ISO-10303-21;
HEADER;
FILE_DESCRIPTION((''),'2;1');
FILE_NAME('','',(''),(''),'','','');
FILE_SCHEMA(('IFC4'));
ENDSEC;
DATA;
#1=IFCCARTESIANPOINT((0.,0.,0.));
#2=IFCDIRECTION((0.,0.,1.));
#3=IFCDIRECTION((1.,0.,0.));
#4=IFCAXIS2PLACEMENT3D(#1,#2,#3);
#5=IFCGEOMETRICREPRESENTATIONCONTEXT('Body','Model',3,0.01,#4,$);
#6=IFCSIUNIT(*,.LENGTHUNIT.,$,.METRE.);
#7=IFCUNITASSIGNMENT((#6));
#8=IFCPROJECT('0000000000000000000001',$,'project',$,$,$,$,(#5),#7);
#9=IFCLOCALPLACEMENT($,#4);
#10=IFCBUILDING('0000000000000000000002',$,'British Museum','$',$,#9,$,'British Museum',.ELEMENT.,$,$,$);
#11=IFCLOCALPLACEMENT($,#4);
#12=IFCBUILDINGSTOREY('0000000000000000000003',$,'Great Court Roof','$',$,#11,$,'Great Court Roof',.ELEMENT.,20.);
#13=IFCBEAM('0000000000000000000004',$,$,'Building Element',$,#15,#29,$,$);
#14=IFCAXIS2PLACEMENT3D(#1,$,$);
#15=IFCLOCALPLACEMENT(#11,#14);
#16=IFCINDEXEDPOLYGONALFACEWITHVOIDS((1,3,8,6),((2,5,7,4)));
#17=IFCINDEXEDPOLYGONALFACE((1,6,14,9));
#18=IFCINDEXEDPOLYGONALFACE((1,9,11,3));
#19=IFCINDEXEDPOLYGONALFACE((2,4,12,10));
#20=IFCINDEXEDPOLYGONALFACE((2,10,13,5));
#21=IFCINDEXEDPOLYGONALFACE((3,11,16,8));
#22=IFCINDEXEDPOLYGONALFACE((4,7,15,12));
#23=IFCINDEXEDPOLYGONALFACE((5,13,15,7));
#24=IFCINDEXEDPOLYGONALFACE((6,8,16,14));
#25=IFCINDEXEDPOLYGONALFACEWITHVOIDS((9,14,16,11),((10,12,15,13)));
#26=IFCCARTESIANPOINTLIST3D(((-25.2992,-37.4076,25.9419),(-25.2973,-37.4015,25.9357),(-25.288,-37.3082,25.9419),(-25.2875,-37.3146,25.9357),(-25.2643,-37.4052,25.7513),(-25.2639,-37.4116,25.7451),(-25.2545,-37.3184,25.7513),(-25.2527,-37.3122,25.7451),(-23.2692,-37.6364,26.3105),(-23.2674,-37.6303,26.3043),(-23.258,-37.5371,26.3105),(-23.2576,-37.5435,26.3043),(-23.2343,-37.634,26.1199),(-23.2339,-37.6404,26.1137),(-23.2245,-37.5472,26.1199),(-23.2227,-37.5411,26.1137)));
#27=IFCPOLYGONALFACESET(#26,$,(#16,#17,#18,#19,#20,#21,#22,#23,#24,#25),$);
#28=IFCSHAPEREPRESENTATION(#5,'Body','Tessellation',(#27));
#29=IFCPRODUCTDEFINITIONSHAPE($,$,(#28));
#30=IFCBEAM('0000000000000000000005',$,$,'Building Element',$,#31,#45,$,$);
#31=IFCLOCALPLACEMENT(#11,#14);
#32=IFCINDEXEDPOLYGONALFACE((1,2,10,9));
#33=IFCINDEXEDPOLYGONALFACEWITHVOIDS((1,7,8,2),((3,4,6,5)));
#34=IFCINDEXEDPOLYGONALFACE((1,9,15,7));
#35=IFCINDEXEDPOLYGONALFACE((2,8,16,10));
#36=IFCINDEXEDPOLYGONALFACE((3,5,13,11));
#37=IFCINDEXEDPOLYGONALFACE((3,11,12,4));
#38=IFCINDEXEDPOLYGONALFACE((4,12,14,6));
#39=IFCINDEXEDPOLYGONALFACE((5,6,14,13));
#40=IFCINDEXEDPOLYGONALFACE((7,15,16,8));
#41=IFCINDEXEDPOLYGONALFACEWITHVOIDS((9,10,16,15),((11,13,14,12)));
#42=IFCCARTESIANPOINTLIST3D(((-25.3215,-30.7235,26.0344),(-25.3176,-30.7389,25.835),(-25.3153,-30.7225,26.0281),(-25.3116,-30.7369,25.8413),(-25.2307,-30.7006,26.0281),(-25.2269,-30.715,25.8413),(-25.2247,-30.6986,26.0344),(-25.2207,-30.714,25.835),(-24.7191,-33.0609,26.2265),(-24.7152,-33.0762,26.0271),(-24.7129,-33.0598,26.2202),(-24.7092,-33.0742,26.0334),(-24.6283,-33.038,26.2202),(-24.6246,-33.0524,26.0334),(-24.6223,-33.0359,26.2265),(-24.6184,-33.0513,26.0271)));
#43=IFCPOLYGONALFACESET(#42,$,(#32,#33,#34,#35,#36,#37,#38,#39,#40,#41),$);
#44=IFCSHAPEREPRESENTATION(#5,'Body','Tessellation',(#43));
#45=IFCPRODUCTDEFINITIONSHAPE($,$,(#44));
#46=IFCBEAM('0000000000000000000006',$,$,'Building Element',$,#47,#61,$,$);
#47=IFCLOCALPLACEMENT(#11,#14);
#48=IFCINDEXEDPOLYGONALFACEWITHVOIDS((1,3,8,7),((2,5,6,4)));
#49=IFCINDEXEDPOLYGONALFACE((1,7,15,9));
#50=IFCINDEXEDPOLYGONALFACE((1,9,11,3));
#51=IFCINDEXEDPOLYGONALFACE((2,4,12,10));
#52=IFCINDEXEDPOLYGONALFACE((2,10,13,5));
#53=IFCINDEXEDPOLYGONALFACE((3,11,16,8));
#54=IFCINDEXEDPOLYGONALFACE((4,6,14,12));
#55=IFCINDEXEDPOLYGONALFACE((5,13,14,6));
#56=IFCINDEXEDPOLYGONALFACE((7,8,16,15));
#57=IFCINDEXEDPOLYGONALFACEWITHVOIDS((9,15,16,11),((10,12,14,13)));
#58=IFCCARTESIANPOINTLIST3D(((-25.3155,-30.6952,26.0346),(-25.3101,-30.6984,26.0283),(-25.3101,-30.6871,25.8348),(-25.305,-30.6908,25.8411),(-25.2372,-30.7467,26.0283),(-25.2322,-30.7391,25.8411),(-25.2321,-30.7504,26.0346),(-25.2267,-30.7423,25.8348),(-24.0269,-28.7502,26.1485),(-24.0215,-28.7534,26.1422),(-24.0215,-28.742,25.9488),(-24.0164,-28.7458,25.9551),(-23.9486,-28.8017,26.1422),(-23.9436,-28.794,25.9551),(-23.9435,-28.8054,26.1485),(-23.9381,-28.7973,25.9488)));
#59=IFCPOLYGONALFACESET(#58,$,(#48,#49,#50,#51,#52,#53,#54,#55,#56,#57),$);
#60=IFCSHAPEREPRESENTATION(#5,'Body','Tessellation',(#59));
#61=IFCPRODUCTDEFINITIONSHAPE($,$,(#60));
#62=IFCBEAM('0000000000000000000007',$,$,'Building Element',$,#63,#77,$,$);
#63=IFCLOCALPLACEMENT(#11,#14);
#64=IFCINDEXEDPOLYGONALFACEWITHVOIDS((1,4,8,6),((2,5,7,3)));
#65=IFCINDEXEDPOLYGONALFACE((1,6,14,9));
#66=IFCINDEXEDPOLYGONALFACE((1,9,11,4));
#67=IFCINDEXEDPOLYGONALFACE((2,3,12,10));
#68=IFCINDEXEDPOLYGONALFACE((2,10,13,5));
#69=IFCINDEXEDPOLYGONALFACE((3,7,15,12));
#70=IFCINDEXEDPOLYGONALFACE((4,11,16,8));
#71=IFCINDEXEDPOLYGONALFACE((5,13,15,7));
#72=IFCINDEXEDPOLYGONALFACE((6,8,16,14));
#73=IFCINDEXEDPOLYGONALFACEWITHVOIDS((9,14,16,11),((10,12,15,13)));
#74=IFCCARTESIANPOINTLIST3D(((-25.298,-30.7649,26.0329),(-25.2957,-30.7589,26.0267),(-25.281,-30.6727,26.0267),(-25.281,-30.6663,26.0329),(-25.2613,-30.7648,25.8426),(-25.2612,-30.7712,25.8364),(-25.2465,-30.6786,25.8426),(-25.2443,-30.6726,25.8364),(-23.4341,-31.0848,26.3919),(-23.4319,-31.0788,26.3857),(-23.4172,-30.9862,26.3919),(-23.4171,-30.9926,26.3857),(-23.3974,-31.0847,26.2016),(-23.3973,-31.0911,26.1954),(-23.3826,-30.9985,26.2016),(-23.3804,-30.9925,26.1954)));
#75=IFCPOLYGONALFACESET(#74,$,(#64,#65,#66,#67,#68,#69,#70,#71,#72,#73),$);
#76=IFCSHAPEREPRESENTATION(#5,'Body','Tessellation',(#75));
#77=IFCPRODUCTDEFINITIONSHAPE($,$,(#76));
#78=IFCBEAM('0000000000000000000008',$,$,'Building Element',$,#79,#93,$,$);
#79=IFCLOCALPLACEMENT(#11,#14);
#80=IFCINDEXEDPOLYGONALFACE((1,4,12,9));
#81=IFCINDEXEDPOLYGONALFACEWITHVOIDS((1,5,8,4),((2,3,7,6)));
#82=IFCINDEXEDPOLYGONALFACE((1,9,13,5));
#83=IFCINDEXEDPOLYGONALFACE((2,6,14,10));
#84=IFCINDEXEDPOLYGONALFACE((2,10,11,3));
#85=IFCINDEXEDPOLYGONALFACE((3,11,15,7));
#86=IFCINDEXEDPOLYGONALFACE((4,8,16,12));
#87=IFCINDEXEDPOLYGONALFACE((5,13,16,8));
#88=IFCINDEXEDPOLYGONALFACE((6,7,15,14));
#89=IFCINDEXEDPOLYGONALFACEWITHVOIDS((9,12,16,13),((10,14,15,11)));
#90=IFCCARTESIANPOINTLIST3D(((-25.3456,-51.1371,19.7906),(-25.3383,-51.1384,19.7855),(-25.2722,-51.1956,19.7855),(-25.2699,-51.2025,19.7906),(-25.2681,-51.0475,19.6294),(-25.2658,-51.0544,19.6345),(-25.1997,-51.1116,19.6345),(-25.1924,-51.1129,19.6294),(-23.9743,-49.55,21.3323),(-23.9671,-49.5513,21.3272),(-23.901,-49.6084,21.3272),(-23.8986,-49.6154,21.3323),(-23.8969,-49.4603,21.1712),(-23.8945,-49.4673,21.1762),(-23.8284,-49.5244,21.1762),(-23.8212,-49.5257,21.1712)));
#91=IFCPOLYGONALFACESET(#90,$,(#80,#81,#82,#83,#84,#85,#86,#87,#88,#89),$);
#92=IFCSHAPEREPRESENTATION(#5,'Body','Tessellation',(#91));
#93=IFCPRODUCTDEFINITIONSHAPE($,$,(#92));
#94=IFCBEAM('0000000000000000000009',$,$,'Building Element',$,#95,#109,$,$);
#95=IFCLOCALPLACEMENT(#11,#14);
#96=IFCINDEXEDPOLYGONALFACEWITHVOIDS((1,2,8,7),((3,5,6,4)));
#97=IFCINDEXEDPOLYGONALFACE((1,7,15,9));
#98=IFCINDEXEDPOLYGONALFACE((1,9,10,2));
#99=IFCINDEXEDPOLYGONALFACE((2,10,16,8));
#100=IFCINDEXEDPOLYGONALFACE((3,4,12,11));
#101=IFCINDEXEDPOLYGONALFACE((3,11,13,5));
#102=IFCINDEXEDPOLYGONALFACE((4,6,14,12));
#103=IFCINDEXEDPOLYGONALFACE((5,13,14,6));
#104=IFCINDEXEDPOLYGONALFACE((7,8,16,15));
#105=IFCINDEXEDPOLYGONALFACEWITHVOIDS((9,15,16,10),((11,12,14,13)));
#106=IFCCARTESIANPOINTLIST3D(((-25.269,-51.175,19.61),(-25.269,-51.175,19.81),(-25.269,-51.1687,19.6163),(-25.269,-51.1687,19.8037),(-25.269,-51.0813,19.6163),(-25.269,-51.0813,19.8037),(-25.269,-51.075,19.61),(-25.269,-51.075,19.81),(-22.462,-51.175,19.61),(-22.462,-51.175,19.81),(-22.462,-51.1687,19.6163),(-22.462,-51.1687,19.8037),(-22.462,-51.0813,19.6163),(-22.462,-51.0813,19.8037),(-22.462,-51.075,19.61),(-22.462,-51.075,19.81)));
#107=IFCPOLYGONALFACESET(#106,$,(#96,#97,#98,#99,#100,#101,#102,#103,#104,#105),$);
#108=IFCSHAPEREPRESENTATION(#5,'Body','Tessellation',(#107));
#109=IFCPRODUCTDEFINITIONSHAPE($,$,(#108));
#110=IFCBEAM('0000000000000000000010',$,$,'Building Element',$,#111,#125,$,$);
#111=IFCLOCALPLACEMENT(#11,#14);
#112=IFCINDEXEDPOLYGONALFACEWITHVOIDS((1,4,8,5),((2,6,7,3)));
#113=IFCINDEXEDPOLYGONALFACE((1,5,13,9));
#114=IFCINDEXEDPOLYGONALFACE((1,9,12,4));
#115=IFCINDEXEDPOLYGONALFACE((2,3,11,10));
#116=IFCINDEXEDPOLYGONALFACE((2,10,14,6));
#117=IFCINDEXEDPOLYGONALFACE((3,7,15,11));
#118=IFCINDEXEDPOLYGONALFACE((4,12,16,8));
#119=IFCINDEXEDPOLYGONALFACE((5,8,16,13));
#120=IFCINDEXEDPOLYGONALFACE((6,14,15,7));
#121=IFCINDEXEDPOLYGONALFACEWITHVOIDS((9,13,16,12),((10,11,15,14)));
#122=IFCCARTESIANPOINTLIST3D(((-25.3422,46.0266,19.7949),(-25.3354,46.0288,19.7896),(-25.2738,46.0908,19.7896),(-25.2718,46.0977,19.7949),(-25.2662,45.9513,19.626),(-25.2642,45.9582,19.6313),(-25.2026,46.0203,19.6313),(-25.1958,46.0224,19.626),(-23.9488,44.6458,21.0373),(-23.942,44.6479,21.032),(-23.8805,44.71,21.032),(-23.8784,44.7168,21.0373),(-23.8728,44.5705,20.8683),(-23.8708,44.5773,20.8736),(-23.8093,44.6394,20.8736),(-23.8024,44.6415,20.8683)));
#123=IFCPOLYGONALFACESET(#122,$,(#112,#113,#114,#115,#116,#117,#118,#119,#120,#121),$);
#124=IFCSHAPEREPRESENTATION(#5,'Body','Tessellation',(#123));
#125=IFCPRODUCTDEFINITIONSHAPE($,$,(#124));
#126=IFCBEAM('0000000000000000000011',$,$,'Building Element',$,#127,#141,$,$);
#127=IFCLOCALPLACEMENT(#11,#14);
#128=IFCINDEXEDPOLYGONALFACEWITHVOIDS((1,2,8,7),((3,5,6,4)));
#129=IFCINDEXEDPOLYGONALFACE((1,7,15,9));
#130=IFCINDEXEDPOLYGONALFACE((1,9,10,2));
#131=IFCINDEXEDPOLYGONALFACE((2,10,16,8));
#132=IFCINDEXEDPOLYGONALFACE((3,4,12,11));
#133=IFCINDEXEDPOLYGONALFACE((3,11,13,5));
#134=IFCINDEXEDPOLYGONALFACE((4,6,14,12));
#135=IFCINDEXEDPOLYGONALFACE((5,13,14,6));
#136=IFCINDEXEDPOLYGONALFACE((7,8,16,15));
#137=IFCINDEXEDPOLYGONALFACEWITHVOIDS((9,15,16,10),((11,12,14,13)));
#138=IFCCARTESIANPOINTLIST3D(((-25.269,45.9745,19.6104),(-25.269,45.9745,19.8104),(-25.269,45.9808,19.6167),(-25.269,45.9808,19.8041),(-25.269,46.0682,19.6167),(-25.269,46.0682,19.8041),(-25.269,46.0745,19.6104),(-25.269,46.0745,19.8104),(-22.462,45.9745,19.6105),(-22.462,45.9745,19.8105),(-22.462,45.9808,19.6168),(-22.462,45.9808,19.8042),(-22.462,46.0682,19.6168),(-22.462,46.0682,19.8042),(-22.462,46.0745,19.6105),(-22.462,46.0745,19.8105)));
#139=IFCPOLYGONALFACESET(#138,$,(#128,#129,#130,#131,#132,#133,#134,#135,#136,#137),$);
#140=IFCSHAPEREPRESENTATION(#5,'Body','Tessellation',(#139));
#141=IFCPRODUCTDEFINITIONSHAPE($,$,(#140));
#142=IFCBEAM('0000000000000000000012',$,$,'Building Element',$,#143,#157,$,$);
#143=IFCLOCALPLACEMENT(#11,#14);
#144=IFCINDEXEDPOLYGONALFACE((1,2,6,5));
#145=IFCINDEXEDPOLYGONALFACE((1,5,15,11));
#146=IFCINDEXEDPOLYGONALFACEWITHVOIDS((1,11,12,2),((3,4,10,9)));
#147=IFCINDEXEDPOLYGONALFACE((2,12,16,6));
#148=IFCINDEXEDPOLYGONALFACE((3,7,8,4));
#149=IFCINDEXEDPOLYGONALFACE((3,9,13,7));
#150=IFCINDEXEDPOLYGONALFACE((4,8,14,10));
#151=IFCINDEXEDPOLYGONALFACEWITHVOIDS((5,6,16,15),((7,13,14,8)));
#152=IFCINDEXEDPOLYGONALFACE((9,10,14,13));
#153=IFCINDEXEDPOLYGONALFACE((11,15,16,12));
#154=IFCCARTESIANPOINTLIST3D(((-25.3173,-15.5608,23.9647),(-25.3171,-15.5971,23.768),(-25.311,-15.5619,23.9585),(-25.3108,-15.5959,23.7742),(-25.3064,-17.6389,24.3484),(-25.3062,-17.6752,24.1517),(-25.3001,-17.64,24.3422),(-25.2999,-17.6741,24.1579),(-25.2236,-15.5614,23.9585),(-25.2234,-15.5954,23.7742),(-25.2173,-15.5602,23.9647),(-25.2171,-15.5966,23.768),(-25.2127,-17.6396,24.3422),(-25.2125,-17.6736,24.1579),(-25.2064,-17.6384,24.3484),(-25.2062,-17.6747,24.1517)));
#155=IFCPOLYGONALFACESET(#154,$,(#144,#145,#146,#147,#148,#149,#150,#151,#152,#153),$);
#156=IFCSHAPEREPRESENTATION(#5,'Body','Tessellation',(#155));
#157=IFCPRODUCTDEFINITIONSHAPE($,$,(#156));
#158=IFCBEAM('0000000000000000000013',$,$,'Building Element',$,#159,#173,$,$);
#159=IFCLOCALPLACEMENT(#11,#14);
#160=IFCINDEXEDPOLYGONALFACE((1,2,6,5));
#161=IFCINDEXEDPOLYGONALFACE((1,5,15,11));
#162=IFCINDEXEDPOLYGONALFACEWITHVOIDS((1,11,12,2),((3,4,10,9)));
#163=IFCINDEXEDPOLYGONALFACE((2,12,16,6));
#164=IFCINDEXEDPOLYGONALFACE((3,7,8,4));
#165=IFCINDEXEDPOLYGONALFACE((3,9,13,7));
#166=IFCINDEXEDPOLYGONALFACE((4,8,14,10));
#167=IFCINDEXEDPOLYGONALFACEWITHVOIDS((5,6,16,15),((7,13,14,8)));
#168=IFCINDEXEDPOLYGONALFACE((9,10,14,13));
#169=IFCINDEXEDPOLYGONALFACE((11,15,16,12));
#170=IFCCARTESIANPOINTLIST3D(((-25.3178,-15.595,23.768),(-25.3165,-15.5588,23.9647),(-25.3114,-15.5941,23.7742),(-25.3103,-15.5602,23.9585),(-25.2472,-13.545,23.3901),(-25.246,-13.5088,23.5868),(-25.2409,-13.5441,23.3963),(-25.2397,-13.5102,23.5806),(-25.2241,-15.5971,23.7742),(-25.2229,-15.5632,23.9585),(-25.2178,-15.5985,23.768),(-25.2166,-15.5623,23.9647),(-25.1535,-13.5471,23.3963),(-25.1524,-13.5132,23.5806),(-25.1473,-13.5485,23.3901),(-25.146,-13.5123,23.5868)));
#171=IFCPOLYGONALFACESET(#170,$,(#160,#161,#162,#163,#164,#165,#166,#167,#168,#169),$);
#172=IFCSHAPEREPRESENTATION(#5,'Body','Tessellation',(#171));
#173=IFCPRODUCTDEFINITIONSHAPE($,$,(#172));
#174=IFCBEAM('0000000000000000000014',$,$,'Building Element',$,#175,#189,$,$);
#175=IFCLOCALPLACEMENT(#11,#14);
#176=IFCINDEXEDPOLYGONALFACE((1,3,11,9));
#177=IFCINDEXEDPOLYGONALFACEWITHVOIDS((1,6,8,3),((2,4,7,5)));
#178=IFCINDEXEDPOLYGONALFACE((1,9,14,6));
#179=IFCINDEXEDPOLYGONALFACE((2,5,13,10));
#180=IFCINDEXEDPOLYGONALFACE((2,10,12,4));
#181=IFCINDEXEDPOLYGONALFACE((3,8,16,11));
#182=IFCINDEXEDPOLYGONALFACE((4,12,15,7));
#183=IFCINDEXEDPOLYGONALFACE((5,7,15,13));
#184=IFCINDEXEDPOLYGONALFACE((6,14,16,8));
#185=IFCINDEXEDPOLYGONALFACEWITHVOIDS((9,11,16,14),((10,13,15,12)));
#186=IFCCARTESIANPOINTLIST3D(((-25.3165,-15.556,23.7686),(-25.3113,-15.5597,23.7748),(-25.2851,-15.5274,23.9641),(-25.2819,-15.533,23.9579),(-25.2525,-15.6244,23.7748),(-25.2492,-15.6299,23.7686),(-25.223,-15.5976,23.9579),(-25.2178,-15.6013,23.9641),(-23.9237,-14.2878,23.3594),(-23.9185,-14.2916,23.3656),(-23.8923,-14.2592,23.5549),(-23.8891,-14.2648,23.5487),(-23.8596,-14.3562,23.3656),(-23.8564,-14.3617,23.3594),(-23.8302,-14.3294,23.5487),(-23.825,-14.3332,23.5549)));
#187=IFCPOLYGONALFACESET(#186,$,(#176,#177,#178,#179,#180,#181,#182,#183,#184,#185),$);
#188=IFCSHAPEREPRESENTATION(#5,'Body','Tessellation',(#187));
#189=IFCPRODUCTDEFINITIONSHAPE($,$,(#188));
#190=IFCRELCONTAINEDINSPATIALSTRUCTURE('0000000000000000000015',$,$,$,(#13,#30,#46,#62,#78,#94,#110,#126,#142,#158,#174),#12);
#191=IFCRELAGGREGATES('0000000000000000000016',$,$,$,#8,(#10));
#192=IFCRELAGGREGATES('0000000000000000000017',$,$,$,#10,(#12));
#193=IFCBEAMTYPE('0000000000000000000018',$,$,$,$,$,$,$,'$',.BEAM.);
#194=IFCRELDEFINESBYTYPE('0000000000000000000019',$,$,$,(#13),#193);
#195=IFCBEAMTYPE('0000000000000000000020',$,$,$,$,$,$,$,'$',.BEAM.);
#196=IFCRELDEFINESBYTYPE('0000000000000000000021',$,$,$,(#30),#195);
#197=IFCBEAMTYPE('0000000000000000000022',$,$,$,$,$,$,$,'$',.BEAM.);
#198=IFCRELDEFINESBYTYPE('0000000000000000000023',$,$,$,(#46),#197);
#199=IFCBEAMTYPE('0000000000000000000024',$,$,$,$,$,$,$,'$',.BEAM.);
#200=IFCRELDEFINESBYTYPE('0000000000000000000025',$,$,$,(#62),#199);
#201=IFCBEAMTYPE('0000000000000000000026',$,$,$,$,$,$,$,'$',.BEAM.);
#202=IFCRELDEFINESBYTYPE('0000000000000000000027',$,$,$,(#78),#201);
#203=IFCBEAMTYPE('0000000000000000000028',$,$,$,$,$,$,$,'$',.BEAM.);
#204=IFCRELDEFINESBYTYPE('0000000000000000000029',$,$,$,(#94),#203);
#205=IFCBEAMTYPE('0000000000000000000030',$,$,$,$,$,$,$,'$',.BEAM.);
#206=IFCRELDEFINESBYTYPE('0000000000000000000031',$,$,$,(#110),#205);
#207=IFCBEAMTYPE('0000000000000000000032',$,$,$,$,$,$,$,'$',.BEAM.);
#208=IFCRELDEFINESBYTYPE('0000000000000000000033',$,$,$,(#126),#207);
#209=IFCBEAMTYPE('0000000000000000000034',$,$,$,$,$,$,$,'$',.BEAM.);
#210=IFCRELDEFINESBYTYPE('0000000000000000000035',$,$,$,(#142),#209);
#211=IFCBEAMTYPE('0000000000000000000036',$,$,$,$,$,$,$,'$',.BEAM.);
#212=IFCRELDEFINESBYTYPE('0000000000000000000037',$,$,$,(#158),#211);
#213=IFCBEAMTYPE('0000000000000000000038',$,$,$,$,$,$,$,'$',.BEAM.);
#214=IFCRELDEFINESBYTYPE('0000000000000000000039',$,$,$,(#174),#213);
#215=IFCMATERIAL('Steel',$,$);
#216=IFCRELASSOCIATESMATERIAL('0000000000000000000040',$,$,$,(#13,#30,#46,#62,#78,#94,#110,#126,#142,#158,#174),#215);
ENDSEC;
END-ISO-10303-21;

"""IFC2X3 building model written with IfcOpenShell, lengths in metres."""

from ifc_helpers import new_model, si_unit, frame, origin_with_axes, origin_2d, place, context, project, spatial, hollow_rectangle, extrude, material, type_object, element, save


model = new_model("IFC2X3")

# Units and contexts
model_context = context("Model", 3, precision=0.01, world=origin_with_axes(), identifier="Body")
ifc_project = project(units=[si_unit("LENGTHUNIT", "METRE")], contexts=[model_context])

# Building, storey
building_placement = place(None, origin_with_axes())
building = spatial("IfcBuilding", under=ifc_project, at=building_placement, Name="British Museum", Description="$", LongName="British Museum", CompositionType="ELEMENT")
storey_placement = place(None, origin_with_axes())
storey = spatial("IfcBuildingStorey", under=building, at=storey_placement, Name="Great Court Roof", Description="$", LongName="Great Court Roof", CompositionType="ELEMENT", Elevation=20.0)

# Beams
ifc_material = material(Name="Steel")
beam_type_1 = type_object("IfcBeamType", ElementType="$", PredefinedType="BEAM")
beam_1_placement = place(None, origin_with_axes())
element("IfcBeam", 1, at=beam_1_placement, inside=storey, type_object=beam_type_1, material=ifc_material, Description="Building Element", context=model_context, shape_type="SweptSolid", body=[
    extrude(hollow_rectangle(XDim=0.1, YDim=0.2, WallThickness=0.0063, InnerFilletRadius=-0.0063, OuterFilletRadius=0.0, at=origin_2d()), frame((-25.2759, -37.3599, 25.8435), z_axis=(0.977915, -0.110241, 0.177567), x_axis=(0.112021, 0.993706, 0.0)), (0.0, 0.0, 1.0), 2.0758),
])
beam_type_2 = type_object("IfcBeamType", ElementType="$", PredefinedType="BEAM")
beam_2_placement = place(None, origin_with_axes())
element("IfcBeam", 2, at=beam_2_placement, inside=storey, type_object=beam_type_2, material=ifc_material, Description="Building Element", context=model_context, shape_type="SweptSolid", body=[
    extrude(hollow_rectangle(XDim=0.1, YDim=0.2, WallThickness=0.0063, InnerFilletRadius=-0.0063, OuterFilletRadius=0.0, at=origin_2d()), frame((-25.2711, -30.7188, 25.9347), z_axis=(0.248778, -0.965305, 0.079343), x_axis=(0.968358, 0.249565, 0.0)), (0.0, 0.0, 1.0), 2.4213),
])
beam_type_3 = type_object("IfcBeamType", ElementType="$", PredefinedType="BEAM")
beam_3_placement = place(None, origin_with_axes())
element("IfcBeam", 3, at=beam_3_placement, inside=storey, type_object=beam_type_3, material=ifc_material, Description="Building Element", context=model_context, shape_type="SweptSolid", body=[
    extrude(hollow_rectangle(XDim=0.1, YDim=0.2, WallThickness=0.0063, InnerFilletRadius=-0.0063, OuterFilletRadius=0.0, at=origin_2d()), frame((-25.2711, -30.7188, 25.9347), z_axis=(0.551641, 0.832654, 0.048783), x_axis=(-0.833646, 0.552299, 0.0)), (0.0, 0.0, 1.0), 2.336),
])
beam_type_4 = type_object("IfcBeamType", ElementType="$", PredefinedType="BEAM")
beam_4_placement = place(None, origin_with_axes())
element("IfcBeam", 4, at=beam_4_placement, inside=storey, type_object=beam_type_4, material=ifc_material, Description="Building Element", context=model_context, shape_type="SweptSolid", body=[
    extrude(hollow_rectangle(XDim=0.1, YDim=0.2, WallThickness=0.0063, InnerFilletRadius=-0.0063, OuterFilletRadius=0.0, at=origin_2d()), frame((-25.2711, -30.7188, 25.9347), z_axis=(0.968303, -0.166189, 0.186467), x_axis=(0.169156, 0.985589, 0.0)), (0.0, 0.0, 1.0), 1.9249),
])
beam_type_5 = type_object("IfcBeamType", ElementType="$", PredefinedType="BEAM")
beam_5_placement = place(None, origin_with_axes())
element("IfcBeam", 5, at=beam_5_placement, inside=storey, type_object=beam_type_5, material=ifc_material, Description="Building Element", context=model_context, shape_type="SweptSolid", body=[
    extrude(hollow_rectangle(XDim=0.1, YDim=0.2, WallThickness=0.0063, InnerFilletRadius=-0.0063, OuterFilletRadius=0.0, at=origin_2d()), frame((-25.269, -51.125, 19.71), z_axis=(0.526768, 0.609708, 0.59226), x_axis=(-0.756698, 0.653764, 0.0)), (0.0, 0.0, 1.0), 2.6031),
])
beam_type_6 = type_object("IfcBeamType", ElementType="$", PredefinedType="BEAM")
beam_6_placement = place(None, origin_with_axes())
element("IfcBeam", 6, at=beam_6_placement, inside=storey, type_object=beam_type_6, material=ifc_material, Description="Building Element", context=model_context, shape_type="SweptSolid", body=[
    extrude(hollow_rectangle(XDim=0.1, YDim=0.2, WallThickness=0.0063, InnerFilletRadius=-0.0063, OuterFilletRadius=0.0, at=origin_2d()), frame((-25.269, -51.125, 19.71), z_axis=(1.0, 0.0, 0.0), x_axis=(0.0, 1.0, 0.0)), (0.0, 0.0, 1.0), 2.807),
])
beam_type_7 = type_object("IfcBeamType", ElementType="$", PredefinedType="BEAM")
beam_7_placement = place(None, origin_with_axes())
element("IfcBeam", 7, at=beam_7_placement, inside=storey, type_object=beam_type_7, material=ifc_material, Description="Building Element", context=model_context, shape_type="SweptSolid", body=[
    extrude(hollow_rectangle(XDim=0.1, YDim=0.2, WallThickness=0.0063, InnerFilletRadius=-0.0063, OuterFilletRadius=0.0, at=origin_2d()), frame((-25.269, 46.0245, 19.7104), z_axis=(0.600077, -0.594677, 0.535039), x_axis=(0.703904, 0.710295, 0.0)), (0.0, 0.0, 1.0), 2.322),
])
beam_type_8 = type_object("IfcBeamType", ElementType="$", PredefinedType="BEAM")
beam_8_placement = place(None, origin_with_axes())
element("IfcBeam", 8, at=beam_8_placement, inside=storey, type_object=beam_type_8, material=ifc_material, Description="Building Element", context=model_context, shape_type="SweptSolid", body=[
    extrude(hollow_rectangle(XDim=0.1, YDim=0.2, WallThickness=0.0063, InnerFilletRadius=-0.0063, OuterFilletRadius=0.0, at=origin_2d()), frame((-25.269, 46.0245, 19.7104), z_axis=(1.0, 0.0, 0.000013), x_axis=(0.0, 1.0, 0.0)), (0.0, 0.0, 1.0), 2.807),
])
beam_type_9 = type_object("IfcBeamType", ElementType="$", PredefinedType="BEAM")
beam_9_placement = place(None, origin_with_axes())
element("IfcBeam", 9, at=beam_9_placement, inside=storey, type_object=beam_type_9, material=ifc_material, Description="Building Element", context=model_context, shape_type="SweptSolid", body=[
    extrude(hollow_rectangle(XDim=0.1, YDim=0.2, WallThickness=0.0063, InnerFilletRadius=-0.0063, OuterFilletRadius=0.0, at=origin_2d()), frame((-25.2672, -15.5787, 23.8664), z_axis=(0.005128, -0.983364, 0.181573), x_axis=(0.999986, 0.005215, 0.0)), (0.0, 0.0, 1.0), 2.1133),
])
beam_type_10 = type_object("IfcBeamType", ElementType="$", PredefinedType="BEAM")
beam_10_placement = place(None, origin_with_axes())
element("IfcBeam", 10, at=beam_10_placement, inside=storey, type_object=beam_type_10, material=ifc_material, Description="Building Element", context=model_context, shape_type="SweptSolid", body=[
    extrude(hollow_rectangle(XDim=0.1, YDim=0.2, WallThickness=0.0063, InnerFilletRadius=-0.0063, OuterFilletRadius=0.0, at=origin_2d()), frame((-25.2672, -15.5787, 23.8664), z_axis=(0.033821, 0.982871, -0.181164), x_axis=(-0.999408, 0.03439, 0.0)), (0.0, 0.0, 1.0), 2.0857),
])
beam_type_11 = type_object("IfcBeamType", ElementType="$", PredefinedType="BEAM")
beam_11_placement = place(None, origin_with_axes())
element("IfcBeam", 11, at=beam_11_placement, inside=storey, type_object=beam_type_11, material=ifc_material, Description="Building Element", context=model_context, shape_type="SweptSolid", body=[
    extrude(hollow_rectangle(XDim=0.1, YDim=0.2, WallThickness=0.0063, InnerFilletRadius=-0.0063, OuterFilletRadius=0.0, at=origin_2d()), frame((-25.2672, -15.5787, 23.8664), z_axis=(0.722562, 0.657903, -0.21229), x_axis=(-0.673249, 0.739416, 0.0)), (0.0, 0.0, 1.0), 1.9276),
])

save(model, "model.ifc")
